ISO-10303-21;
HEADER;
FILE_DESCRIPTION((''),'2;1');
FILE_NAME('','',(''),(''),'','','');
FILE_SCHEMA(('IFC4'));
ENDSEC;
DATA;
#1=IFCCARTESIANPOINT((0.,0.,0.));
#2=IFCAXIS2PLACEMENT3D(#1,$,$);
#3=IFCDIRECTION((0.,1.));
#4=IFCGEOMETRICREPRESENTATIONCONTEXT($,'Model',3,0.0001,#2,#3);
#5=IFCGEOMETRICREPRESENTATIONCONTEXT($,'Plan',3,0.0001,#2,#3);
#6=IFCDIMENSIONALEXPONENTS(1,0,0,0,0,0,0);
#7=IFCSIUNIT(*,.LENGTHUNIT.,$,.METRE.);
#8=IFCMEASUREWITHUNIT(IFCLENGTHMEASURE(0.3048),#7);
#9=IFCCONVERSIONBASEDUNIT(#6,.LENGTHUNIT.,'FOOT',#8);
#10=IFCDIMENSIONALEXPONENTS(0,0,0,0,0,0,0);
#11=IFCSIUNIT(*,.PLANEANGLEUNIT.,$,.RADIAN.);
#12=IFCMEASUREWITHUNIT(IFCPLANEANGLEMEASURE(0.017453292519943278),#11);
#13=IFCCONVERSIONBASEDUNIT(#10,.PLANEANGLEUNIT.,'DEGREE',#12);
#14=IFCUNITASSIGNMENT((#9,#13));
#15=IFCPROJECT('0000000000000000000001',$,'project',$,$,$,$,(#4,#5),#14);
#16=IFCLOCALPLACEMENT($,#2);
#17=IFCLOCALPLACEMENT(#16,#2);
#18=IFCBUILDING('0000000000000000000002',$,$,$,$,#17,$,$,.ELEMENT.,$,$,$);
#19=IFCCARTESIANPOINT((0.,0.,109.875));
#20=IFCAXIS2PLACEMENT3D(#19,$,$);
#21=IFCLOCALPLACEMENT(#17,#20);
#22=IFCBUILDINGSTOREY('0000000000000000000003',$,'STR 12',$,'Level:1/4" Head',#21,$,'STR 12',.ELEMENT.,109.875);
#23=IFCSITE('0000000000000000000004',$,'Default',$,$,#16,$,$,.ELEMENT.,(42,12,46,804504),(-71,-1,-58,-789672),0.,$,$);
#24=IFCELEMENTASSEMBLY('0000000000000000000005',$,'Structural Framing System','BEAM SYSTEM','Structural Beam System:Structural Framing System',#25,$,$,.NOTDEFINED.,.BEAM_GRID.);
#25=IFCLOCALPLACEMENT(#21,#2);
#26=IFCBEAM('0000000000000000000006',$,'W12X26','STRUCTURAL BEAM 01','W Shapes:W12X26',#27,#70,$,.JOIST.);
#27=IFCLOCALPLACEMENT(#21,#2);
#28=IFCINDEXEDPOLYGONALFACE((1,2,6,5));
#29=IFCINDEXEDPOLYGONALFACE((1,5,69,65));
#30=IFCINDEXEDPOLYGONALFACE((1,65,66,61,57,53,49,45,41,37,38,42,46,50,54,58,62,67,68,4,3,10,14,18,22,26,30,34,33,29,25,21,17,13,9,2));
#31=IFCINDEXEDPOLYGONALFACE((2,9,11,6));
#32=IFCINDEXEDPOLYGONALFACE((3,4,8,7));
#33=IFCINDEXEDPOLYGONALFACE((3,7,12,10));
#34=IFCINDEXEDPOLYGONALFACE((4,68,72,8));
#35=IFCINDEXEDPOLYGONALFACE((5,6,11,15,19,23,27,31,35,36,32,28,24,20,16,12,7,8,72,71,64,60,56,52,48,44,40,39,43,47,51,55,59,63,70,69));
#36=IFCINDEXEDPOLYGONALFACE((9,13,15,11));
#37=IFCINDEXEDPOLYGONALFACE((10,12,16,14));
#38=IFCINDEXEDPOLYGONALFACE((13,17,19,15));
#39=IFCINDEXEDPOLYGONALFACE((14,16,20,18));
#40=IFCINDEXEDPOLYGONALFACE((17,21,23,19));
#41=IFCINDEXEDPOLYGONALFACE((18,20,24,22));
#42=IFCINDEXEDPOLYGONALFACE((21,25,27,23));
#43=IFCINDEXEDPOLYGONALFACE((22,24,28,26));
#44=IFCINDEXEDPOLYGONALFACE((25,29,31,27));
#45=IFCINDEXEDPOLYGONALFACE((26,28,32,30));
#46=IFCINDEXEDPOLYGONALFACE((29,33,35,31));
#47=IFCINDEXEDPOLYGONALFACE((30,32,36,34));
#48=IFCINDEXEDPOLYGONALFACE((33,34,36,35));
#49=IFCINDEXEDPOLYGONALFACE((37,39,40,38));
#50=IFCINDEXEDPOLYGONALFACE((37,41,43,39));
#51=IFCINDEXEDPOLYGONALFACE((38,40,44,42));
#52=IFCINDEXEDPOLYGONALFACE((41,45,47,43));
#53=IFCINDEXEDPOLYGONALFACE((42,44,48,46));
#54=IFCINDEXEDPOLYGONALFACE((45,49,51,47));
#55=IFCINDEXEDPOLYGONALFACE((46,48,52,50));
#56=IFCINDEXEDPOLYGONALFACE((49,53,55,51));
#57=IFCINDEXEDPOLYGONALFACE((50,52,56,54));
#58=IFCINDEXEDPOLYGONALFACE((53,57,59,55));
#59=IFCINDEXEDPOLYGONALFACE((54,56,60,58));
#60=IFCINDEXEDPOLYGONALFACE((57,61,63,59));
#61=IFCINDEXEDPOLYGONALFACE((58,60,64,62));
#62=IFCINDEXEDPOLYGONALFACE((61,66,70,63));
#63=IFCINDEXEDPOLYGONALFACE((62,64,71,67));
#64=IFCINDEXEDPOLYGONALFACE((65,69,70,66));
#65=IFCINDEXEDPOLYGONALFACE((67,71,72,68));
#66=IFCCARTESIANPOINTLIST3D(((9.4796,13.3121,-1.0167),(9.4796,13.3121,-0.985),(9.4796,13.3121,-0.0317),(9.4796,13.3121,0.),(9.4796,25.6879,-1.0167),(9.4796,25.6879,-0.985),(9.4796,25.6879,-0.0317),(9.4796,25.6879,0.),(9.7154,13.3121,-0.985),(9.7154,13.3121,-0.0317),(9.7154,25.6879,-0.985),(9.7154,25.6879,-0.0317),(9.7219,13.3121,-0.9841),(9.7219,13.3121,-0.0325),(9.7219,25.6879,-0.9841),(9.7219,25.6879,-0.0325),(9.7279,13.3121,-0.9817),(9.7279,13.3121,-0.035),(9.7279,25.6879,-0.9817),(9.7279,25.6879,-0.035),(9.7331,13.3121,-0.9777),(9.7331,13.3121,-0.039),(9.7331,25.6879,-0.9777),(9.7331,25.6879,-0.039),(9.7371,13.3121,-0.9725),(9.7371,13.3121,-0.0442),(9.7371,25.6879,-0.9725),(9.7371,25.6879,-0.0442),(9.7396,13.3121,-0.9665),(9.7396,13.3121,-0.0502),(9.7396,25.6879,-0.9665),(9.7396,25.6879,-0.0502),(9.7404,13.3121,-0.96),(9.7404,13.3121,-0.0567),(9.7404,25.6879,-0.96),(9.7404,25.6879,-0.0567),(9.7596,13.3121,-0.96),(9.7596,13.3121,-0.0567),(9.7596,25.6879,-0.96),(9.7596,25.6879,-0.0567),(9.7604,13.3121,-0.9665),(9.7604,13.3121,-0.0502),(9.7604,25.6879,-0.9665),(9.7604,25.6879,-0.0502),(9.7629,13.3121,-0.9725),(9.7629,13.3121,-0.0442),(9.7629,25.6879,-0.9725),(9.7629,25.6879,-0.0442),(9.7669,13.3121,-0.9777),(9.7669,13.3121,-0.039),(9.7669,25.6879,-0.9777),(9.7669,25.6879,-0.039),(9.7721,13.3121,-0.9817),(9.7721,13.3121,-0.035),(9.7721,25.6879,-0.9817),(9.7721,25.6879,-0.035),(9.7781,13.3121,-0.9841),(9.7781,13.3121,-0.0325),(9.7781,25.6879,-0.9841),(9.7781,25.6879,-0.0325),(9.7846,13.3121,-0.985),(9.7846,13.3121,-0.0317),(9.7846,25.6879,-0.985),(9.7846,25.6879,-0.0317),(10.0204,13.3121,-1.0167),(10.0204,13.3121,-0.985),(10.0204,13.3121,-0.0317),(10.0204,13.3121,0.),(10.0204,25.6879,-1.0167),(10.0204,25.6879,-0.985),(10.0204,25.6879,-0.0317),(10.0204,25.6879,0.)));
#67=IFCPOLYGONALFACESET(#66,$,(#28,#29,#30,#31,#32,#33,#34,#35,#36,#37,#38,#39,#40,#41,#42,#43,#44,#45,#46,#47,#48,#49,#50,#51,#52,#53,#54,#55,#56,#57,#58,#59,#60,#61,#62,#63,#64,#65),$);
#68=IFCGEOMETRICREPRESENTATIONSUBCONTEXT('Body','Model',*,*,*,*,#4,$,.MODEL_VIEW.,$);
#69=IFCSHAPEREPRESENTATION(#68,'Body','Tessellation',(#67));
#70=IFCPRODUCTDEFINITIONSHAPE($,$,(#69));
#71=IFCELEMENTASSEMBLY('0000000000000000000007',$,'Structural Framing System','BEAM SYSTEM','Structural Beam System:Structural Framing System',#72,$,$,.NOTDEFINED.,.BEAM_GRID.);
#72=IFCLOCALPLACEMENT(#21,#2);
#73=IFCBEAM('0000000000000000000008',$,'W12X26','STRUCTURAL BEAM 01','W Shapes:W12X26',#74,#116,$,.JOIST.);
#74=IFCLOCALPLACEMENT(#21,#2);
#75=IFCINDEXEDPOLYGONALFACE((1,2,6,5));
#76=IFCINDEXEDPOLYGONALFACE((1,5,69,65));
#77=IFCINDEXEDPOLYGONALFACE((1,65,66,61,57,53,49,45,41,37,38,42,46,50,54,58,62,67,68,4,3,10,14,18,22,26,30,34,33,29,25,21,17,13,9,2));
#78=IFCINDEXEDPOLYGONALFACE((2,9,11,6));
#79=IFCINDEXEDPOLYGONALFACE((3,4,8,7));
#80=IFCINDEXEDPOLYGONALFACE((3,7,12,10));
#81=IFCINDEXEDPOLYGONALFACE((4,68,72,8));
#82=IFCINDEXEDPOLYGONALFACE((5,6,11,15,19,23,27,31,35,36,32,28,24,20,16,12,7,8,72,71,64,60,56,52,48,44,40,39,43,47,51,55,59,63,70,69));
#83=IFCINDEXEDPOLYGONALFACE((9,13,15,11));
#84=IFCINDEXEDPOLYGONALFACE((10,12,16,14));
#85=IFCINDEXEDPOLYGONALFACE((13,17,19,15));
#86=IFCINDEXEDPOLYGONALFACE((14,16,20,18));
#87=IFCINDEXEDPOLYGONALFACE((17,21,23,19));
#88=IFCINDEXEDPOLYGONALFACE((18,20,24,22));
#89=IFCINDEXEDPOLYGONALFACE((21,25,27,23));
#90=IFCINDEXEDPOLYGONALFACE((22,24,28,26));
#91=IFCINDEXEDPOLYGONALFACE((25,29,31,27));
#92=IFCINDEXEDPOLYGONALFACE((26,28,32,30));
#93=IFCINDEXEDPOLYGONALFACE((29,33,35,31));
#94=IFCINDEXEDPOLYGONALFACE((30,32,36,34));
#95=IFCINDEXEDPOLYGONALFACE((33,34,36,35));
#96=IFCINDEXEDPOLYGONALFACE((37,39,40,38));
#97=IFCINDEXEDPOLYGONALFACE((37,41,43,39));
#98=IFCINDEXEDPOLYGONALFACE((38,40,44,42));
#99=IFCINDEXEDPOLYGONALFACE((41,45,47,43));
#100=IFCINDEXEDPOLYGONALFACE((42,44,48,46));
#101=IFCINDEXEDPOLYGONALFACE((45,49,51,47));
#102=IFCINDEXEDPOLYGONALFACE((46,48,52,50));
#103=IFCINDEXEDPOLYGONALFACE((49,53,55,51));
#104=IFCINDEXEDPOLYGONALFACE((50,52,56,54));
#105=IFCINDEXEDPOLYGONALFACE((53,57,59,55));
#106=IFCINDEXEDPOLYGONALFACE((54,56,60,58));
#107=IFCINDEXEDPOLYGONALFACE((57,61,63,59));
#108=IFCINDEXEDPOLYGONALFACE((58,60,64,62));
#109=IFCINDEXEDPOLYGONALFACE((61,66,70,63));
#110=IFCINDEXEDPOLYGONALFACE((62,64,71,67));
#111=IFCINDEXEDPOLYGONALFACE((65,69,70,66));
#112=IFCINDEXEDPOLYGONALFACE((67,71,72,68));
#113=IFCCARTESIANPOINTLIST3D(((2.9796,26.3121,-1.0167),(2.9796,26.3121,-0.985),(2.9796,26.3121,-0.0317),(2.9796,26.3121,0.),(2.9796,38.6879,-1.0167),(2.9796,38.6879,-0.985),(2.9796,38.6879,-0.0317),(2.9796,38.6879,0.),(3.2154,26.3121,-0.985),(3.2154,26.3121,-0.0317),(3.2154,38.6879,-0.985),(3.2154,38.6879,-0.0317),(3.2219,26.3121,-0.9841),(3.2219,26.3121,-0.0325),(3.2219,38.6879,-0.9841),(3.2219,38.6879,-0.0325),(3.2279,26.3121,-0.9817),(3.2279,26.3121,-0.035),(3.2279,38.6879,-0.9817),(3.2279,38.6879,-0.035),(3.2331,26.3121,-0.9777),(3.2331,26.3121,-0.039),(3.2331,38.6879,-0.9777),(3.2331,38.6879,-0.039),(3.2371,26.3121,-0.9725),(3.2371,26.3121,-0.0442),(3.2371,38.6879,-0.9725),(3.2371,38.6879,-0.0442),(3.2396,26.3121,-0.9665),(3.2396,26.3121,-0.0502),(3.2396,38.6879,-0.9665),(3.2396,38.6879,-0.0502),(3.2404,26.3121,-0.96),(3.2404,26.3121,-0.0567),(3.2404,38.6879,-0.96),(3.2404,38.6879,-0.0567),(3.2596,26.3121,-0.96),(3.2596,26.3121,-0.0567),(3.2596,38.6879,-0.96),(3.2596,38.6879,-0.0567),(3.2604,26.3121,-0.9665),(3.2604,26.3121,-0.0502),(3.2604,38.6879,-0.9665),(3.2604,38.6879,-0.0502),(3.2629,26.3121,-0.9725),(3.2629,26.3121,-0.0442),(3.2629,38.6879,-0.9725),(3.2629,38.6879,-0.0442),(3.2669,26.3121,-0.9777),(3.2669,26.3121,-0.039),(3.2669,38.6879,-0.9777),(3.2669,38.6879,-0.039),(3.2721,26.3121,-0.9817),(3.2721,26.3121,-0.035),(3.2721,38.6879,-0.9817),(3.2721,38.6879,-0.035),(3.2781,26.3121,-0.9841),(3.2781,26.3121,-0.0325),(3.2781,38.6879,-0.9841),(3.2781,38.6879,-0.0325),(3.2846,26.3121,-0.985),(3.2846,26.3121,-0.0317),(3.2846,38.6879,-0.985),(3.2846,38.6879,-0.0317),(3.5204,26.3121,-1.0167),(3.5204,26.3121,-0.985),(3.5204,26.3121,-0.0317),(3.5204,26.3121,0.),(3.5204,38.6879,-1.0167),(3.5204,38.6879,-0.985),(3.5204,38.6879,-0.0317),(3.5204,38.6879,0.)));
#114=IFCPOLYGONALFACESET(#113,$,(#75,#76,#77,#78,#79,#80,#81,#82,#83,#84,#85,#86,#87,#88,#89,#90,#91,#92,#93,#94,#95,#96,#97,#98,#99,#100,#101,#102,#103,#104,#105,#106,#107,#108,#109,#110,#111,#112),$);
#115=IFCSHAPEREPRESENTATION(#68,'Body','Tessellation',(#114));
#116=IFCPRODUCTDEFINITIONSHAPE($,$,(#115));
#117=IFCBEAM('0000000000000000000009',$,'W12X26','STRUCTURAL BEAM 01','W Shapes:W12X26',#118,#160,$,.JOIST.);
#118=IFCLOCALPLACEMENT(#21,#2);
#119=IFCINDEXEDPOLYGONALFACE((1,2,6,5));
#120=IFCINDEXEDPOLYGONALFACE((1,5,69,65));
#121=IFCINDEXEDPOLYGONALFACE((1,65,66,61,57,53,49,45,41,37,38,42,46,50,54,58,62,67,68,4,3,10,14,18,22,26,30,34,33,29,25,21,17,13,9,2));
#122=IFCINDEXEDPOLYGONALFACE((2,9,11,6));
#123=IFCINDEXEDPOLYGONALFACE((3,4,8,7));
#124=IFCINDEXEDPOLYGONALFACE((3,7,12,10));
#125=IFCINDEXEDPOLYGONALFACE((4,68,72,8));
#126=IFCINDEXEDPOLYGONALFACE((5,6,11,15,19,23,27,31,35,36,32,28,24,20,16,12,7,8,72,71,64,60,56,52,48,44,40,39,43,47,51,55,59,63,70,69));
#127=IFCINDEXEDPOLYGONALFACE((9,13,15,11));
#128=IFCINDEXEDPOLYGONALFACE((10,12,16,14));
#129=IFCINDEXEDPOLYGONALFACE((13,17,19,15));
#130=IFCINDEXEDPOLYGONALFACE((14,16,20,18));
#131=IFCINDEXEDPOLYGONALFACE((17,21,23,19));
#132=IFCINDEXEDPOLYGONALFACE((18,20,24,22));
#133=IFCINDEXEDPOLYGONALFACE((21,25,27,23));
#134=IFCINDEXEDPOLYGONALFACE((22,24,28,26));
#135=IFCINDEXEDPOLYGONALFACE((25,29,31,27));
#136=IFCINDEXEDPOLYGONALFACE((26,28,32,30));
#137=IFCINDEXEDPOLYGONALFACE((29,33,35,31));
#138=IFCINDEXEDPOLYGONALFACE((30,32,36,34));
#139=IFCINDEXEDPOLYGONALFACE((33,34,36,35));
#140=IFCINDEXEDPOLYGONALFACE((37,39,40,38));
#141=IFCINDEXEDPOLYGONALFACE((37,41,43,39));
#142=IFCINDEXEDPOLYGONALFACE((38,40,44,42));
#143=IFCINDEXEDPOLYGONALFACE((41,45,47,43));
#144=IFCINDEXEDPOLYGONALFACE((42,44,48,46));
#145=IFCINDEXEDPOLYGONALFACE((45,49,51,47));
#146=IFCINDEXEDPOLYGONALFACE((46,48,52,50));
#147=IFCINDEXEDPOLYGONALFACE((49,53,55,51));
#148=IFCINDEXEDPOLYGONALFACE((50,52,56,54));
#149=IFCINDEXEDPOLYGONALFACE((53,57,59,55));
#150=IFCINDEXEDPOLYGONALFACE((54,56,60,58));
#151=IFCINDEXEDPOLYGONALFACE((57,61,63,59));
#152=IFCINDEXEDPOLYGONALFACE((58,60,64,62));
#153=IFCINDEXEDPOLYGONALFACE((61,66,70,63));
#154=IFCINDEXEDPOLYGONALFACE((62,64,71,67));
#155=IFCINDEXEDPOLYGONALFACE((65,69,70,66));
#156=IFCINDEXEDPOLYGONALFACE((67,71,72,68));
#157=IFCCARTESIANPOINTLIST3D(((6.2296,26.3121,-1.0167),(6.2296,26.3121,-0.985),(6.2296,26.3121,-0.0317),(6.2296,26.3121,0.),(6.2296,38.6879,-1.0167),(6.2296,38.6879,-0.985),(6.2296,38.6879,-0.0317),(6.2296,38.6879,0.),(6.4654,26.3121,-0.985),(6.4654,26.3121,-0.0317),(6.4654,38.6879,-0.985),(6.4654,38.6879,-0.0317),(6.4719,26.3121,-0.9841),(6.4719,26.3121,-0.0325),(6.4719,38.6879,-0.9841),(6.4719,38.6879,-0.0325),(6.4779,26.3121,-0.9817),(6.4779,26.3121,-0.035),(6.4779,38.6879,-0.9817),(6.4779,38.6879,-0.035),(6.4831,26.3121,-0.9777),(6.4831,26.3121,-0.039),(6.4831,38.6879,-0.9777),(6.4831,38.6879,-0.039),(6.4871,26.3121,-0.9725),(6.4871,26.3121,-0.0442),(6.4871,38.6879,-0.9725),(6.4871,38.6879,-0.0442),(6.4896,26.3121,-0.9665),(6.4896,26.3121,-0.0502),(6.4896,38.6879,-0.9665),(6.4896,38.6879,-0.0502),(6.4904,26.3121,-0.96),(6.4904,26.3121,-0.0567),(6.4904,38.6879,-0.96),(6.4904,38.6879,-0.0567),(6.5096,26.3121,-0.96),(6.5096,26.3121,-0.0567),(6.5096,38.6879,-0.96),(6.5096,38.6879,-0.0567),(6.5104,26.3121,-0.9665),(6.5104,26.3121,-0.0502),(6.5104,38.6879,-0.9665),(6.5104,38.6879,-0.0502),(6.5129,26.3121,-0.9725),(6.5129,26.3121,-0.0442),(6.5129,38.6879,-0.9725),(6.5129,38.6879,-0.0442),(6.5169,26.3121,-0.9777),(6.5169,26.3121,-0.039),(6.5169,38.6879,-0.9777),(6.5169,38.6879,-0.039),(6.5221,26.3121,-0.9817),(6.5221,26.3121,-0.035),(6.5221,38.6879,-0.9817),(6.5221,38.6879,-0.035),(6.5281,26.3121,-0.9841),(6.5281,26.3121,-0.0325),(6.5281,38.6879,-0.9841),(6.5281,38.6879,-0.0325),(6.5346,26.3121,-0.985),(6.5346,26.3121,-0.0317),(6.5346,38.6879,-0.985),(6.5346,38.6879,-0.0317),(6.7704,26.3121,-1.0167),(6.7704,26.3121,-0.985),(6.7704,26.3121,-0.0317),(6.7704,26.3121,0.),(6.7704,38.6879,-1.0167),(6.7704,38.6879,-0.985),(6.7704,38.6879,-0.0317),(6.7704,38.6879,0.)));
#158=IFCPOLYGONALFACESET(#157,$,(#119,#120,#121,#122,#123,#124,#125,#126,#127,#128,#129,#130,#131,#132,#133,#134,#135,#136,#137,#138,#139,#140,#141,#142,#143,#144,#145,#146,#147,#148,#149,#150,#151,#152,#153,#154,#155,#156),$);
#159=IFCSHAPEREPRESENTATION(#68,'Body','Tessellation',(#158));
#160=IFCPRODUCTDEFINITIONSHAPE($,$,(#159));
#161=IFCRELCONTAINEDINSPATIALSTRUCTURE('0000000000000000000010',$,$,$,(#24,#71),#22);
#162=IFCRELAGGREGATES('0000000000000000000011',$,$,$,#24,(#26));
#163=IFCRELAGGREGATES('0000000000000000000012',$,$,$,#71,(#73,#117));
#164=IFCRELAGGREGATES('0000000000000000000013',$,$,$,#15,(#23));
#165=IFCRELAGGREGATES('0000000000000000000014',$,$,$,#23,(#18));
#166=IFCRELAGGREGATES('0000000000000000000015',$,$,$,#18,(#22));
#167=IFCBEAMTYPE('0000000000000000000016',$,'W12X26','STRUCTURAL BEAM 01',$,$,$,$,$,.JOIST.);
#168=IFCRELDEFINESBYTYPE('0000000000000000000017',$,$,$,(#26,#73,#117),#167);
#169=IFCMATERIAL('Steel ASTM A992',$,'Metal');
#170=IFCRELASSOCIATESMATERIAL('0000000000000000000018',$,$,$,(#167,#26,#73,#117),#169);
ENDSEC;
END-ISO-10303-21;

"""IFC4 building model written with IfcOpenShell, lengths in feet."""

from ifc_helpers import new_model, entity, si_unit, converted_unit, direction, frame, origin, place, context, subcontext, project, spatial, line, arc, indexed_curve, outline, extrude, source, transform, mapped, material, type_object, type_shapes, element, aggregate, save


model = new_model("IFC4")

# Units and contexts
model_context = context("Model", 3, precision=0.0001, world=origin(), true_north=direction((0.0, 1.0)))
plan_context = context("Plan", 3, precision=0.0001, world=origin(), true_north=direction((0.0, 1.0)))
body_context = subcontext(model_context, "Body", "Model", "MODEL_VIEW")
ifc_project = project(units=[converted_unit("LENGTHUNIT", "FOOT", entity("IfcLengthMeasure", 0.3048), si_unit("LENGTHUNIT", "METRE"), dimensions=[1, 0, 0, 0, 0, 0, 0]), converted_unit("PLANEANGLEUNIT", "DEGREE", entity("IfcPlaneAngleMeasure", 0.017453292519943278), si_unit("PLANEANGLEUNIT", "RADIAN"), dimensions=[0, 0, 0, 0, 0, 0, 0])], contexts=[model_context, plan_context])

# Site, building, storey
site_placement = place(None, origin())
site = spatial("IfcSite", under=ifc_project, at=site_placement, Name="Default", CompositionType="ELEMENT", RefLatitude=(42, 12, 46, 804504), RefLongitude=(-71, -1, -58, -789672), RefElevation=0.0)
building_placement = place(site_placement, origin())
building = spatial("IfcBuilding", under=site, at=building_placement, CompositionType="ELEMENT")
storey_placement = place(building_placement, frame((0.0, 0.0, 109.875)))
storey = spatial("IfcBuildingStorey", under=building, at=storey_placement, Name="STR 12", ObjectType="Level:1/4\" Head", LongName="STR 12", CompositionType="ELEMENT", Elevation=109.875)

# Element assemblies, beams
ifc_material = material(Name="Steel ASTM A992", Category="Metal")
beam_type = type_object("IfcBeamType", Name="W12X26", Description="STRUCTURAL BEAM 01", PredefinedType="JOIST", material=ifc_material)
shared_shape = source(origin(), body_context, "Body", "SweptSolid", [
    extrude(outline(indexed_curve([(-0.2704, -0.4767), (-0.2704, -0.5083), (0.2704, -0.5083), (0.2704, -0.4767), (0.0346, -0.4767), (0.0169, -0.4693), (0.0096, -0.4517), (0.0096, 0.4517), (0.0169, 0.4693), (0.0346, 0.4767), (0.2704, 0.4767), (0.2704, 0.5083), (-0.2704, 0.5083), (-0.2704, 0.4767), (-0.0346, 0.4767), (-0.0169, 0.4693), (-0.0096, 0.4517), (-0.0096, -0.4517), (-0.0169, -0.4693), (-0.0346, -0.4767)], segments=[line(1, 2, 3, 4, 5), arc(5, 6, 7), line(7, 8), arc(8, 9, 10), line(10, 11, 12, 13, 14, 15), arc(15, 16, 17), line(17, 18), arc(18, 19, 20), line(20, 1)], self_intersect=False)), frame((-6.1879, 0.0, 0.0), z_axis=(-1.0, 0.0, 0.0), x_axis=(0.0, -1.0, 0.0)), (0.0, 0.0, -1.0), 12.3758),
])
type_shapes(beam_type, [shared_shape])
assembly_1_placement = place(storey_placement, origin())
assembly_1 = element("IfcElementAssembly", 1, at=assembly_1_placement, inside=storey, Name="Structural Framing System", Description="BEAM SYSTEM", ObjectType="Structural Beam System:Structural Framing System", AssemblyPlace="NOTDEFINED", PredefinedType="BEAM_GRID")
beam_1_placement = place(assembly_1_placement, frame((9.75, 19.5, -0.5083), z_axis=(0.0, 0.0, 1.0), x_axis=(0.0, 1.0, 0.0)))
beam_1 = element("IfcBeam", 2, at=beam_1_placement, type_object=beam_type, material=ifc_material, Name="W12X26", Description="STRUCTURAL BEAM 01", ObjectType="W Shapes:W12X26", PredefinedType="JOIST", context=body_context, shape_type="MappedRepresentation", body=[
    mapped(shared_shape, transform((0.0, 0.0, 0.0), scale=1.0)),
])
aggregate(assembly_1, [beam_1])
assembly_2_placement = place(storey_placement, origin())
assembly_2 = element("IfcElementAssembly", 3, at=assembly_2_placement, inside=storey, Name="Structural Framing System", Description="BEAM SYSTEM", ObjectType="Structural Beam System:Structural Framing System", AssemblyPlace="NOTDEFINED", PredefinedType="BEAM_GRID")
beam_2_placement = place(assembly_2_placement, frame((3.25, 32.5, -0.5083), z_axis=(0.0, 0.0, 1.0), x_axis=(0.0, 1.0, 0.0)))
beam_2 = element("IfcBeam", 4, at=beam_2_placement, type_object=beam_type, material=ifc_material, Name="W12X26", Description="STRUCTURAL BEAM 01", ObjectType="W Shapes:W12X26", PredefinedType="JOIST", context=body_context, shape_type="MappedRepresentation", body=[
    mapped(shared_shape, transform((0.0, 0.0, 0.0), scale=1.0)),
])
beam_3_placement = place(assembly_2_placement, frame((6.5, 32.5, -0.5083), z_axis=(0.0, 0.0, 1.0), x_axis=(0.0, 1.0, 0.0)))
beam_3 = element("IfcBeam", 5, at=beam_3_placement, type_object=beam_type, material=ifc_material, Name="W12X26", Description="STRUCTURAL BEAM 01", ObjectType="W Shapes:W12X26", PredefinedType="JOIST", context=body_context, shape_type="MappedRepresentation", body=[
    mapped(shared_shape, transform((0.0, 0.0, 0.0), scale=1.0)),
])
aggregate(assembly_2, [beam_2, beam_3])

save(model, "model.ifc")
